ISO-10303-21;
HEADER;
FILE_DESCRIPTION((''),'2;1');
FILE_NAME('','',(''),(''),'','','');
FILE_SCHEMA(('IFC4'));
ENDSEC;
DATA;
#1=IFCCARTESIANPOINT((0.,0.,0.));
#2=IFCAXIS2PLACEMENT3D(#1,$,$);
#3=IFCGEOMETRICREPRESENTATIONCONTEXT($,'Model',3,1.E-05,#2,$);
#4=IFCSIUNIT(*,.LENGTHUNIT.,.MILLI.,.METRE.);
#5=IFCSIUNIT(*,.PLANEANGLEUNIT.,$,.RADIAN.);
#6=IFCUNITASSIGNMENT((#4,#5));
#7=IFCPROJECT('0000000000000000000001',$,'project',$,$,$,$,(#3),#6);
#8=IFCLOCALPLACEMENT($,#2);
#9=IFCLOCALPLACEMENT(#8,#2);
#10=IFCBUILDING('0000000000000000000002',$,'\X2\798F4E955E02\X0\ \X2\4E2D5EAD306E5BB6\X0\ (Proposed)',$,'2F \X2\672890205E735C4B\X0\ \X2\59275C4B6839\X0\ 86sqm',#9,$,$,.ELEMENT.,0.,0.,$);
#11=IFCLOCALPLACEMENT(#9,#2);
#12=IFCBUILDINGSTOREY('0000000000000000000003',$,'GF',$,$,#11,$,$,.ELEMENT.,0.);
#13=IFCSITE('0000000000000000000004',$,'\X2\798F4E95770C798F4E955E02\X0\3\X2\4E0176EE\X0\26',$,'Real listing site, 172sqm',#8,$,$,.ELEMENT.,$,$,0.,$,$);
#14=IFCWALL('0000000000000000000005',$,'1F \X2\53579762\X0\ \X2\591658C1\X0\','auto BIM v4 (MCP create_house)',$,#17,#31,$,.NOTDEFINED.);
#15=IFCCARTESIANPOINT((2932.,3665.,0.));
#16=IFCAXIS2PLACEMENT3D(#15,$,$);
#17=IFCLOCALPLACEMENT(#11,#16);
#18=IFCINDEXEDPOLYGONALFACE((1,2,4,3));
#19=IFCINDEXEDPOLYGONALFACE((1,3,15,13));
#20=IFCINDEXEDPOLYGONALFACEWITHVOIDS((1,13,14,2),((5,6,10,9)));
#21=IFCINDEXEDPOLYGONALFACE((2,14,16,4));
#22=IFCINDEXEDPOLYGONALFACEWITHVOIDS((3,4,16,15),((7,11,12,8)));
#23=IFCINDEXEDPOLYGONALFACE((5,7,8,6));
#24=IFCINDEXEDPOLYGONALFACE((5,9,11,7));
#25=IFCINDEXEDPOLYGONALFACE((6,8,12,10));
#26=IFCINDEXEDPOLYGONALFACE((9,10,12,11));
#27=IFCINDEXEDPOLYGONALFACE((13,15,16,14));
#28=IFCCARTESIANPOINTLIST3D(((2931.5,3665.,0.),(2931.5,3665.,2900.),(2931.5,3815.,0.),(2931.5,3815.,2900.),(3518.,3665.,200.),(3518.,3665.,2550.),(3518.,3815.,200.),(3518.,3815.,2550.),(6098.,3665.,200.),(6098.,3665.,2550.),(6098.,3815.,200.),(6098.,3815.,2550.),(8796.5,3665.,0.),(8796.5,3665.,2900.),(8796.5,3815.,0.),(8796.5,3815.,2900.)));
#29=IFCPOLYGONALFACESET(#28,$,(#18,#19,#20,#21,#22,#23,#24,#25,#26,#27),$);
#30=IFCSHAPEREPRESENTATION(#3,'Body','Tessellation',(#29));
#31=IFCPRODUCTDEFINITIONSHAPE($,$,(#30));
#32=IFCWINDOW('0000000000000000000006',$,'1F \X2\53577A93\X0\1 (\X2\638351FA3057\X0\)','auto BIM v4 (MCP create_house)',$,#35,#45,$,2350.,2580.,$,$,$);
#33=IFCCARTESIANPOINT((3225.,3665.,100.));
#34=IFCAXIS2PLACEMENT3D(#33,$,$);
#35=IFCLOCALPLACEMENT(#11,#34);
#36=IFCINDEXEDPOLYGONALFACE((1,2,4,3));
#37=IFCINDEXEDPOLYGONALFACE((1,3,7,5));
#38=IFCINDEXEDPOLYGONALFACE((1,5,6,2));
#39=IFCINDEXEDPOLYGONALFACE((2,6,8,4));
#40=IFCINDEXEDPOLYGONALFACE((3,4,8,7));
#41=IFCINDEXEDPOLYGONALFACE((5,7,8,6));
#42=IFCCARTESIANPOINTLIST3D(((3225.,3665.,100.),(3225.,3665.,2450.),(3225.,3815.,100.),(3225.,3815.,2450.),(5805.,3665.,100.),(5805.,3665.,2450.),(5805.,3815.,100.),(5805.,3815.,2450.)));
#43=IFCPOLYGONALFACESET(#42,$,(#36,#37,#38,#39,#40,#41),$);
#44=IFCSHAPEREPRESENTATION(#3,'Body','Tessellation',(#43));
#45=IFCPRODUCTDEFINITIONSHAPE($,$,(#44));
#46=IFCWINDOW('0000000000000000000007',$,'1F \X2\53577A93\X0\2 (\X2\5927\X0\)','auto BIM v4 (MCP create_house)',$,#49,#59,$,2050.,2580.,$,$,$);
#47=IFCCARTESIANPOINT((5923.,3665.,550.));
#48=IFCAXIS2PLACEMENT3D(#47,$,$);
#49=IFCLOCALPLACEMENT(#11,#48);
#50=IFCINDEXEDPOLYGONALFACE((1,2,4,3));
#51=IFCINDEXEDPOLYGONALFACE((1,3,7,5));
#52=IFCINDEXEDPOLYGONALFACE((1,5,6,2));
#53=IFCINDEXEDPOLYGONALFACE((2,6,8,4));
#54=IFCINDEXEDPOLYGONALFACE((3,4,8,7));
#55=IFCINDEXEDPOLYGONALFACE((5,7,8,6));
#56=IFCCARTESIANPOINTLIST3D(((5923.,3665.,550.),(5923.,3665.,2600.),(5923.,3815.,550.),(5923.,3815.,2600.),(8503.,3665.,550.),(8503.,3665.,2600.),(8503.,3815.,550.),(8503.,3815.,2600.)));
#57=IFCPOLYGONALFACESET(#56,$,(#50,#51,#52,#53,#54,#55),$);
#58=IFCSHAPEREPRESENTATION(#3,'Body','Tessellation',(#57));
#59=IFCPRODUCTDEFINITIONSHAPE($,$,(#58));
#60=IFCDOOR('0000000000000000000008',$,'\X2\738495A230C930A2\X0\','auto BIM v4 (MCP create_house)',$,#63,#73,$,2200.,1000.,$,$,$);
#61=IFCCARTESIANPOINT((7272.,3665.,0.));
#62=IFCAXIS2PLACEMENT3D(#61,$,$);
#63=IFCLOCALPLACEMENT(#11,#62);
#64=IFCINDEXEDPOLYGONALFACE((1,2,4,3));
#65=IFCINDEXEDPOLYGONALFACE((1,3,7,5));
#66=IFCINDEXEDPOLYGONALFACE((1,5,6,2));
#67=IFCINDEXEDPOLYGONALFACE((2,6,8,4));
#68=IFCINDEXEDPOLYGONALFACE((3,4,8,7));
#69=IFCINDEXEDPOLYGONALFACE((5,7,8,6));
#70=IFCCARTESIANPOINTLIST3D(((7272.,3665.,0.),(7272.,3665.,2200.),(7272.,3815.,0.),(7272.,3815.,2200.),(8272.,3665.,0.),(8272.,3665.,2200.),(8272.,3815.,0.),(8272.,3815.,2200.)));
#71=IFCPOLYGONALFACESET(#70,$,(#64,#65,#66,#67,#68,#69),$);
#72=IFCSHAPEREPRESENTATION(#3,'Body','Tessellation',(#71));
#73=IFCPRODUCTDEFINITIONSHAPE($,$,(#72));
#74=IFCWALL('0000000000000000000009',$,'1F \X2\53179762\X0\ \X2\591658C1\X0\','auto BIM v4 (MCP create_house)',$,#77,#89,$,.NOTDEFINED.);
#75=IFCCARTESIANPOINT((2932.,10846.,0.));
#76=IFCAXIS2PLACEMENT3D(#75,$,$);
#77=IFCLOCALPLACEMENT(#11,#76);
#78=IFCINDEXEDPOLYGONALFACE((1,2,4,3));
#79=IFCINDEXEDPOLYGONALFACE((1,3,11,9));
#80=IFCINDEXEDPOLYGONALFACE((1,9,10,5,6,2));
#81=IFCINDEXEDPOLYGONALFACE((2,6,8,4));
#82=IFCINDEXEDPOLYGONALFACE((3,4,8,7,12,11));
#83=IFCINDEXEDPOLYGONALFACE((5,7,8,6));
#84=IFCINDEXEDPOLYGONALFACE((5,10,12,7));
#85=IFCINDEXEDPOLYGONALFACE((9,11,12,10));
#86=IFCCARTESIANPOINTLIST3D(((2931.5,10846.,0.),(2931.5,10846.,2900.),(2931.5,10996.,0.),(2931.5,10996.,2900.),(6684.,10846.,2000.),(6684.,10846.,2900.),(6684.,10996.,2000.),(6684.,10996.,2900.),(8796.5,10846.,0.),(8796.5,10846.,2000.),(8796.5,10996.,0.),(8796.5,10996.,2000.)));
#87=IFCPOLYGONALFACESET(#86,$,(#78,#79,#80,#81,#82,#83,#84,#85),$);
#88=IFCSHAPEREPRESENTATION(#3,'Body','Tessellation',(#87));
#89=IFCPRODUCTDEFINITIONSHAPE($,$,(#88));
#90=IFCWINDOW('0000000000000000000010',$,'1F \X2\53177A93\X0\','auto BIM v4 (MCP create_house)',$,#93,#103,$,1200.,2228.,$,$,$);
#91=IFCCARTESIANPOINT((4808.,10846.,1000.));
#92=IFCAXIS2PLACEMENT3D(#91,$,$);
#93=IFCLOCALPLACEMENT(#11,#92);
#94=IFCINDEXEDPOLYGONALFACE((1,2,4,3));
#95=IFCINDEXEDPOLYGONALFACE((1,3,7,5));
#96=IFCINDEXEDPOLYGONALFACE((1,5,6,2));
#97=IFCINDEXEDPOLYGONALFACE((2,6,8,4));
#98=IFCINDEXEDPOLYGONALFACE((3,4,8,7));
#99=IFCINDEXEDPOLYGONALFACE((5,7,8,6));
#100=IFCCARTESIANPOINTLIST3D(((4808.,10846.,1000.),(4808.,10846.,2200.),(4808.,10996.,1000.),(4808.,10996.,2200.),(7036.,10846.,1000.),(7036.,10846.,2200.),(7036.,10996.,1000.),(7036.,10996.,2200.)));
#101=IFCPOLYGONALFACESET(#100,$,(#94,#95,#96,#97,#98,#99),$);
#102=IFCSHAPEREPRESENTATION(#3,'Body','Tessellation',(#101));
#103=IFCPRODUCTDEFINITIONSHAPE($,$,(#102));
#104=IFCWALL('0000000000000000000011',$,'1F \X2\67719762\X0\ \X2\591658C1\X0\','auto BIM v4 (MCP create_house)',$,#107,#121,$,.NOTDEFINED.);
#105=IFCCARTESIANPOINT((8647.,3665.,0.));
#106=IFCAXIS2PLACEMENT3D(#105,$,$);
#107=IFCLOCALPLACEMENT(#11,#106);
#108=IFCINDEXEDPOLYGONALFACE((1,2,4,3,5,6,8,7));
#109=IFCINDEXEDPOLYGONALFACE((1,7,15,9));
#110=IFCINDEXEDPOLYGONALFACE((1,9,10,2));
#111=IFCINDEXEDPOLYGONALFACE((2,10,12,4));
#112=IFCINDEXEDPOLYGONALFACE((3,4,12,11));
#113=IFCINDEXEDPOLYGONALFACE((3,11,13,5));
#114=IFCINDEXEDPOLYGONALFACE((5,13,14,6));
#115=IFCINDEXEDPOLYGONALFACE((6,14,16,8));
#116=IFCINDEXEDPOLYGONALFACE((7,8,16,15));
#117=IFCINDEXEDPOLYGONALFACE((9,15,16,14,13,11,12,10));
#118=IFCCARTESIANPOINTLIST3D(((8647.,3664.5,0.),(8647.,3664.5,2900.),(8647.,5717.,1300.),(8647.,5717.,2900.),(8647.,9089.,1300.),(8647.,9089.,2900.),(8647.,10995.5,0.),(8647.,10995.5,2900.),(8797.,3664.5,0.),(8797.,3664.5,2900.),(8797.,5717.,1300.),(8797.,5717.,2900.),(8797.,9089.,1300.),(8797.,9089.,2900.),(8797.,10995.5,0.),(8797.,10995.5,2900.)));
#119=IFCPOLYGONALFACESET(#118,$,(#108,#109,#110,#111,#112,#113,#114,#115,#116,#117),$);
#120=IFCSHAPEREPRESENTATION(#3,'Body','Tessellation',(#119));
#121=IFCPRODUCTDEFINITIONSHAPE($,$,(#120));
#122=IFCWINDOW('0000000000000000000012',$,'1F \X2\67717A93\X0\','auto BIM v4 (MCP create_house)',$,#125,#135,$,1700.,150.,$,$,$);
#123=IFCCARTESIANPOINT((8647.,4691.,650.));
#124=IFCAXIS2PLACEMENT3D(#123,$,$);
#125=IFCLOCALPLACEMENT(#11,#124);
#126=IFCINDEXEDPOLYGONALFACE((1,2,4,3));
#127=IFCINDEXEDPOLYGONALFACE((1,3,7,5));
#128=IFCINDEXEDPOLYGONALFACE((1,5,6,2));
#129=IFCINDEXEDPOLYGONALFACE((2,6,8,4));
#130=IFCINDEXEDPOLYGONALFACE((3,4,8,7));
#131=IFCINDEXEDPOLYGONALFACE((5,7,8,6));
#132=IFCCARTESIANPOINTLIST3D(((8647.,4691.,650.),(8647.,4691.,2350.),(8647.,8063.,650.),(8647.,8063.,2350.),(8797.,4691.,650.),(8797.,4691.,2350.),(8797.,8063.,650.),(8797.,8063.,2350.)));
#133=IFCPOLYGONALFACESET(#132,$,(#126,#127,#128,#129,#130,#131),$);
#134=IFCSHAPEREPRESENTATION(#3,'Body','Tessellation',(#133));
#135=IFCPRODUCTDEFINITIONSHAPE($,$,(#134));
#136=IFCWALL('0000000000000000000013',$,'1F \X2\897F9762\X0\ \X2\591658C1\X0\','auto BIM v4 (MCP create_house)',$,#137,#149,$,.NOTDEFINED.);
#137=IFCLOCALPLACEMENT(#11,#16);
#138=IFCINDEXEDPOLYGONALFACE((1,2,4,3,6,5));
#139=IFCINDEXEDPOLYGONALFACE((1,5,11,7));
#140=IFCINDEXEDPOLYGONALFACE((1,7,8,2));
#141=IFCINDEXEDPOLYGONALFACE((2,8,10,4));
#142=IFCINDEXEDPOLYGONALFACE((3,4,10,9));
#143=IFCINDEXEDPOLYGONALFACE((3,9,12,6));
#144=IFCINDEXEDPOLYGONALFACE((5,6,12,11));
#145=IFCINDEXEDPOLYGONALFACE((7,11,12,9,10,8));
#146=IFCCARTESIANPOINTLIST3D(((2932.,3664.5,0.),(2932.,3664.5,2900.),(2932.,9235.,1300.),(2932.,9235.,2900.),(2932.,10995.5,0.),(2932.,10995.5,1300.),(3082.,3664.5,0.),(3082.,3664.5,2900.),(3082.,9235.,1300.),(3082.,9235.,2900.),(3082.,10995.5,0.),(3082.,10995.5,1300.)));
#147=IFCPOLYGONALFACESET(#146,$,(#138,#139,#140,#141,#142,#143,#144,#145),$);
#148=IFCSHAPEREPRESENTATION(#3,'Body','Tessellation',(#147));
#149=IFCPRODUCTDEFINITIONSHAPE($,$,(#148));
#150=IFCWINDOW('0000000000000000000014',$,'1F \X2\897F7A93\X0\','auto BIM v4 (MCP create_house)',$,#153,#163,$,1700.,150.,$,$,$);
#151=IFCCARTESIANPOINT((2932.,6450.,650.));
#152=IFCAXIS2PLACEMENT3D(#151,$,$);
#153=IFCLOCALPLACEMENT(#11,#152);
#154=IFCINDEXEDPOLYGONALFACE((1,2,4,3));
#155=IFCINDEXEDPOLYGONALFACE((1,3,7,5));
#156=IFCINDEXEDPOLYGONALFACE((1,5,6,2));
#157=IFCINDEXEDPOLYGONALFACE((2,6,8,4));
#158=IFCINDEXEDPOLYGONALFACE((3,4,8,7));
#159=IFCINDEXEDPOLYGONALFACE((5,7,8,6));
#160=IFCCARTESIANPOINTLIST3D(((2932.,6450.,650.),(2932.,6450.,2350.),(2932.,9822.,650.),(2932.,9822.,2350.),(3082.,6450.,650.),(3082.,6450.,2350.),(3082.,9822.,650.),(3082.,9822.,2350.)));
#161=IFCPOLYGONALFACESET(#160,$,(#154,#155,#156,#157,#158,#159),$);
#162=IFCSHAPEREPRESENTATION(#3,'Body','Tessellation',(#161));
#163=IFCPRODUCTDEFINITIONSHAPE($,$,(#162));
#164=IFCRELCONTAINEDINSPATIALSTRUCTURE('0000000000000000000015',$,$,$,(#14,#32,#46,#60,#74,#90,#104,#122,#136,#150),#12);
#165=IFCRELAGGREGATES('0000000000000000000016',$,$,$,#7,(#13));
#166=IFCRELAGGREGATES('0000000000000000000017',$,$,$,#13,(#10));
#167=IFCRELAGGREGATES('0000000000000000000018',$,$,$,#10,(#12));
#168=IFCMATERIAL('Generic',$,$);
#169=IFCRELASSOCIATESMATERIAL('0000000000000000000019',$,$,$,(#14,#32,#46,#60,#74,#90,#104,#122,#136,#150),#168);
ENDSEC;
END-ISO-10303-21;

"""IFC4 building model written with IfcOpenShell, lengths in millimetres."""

from ifc_helpers import new_model, si_unit, frame, frame_2d, origin, place, context, project, spatial, rectangle, extrude, material, element, fill, save


model = new_model("IFC4")

# Units and contexts
model_context = context("Model", 3, precision=1e-05, world=origin())
ifc_project = project(units=[si_unit("LENGTHUNIT", "METRE", prefix="MILLI"), si_unit("PLANEANGLEUNIT", "RADIAN")], contexts=[model_context])

# Site, building, storey
site_placement = place(None, origin())
site = spatial("IfcSite", under=ifc_project, at=site_placement, Name="福井県福井市3丁目26", ObjectType="Real listing site, 172sqm", CompositionType="ELEMENT", RefElevation=0.0)
building_placement = place(site_placement, origin())
building = spatial("IfcBuilding", under=site, at=building_placement, Name="福井市 中庭の家 (Proposed)", ObjectType="2F 木造平屋 大屋根 86sqm", CompositionType="ELEMENT", ElevationOfRefHeight=0.0, ElevationOfTerrain=0.0)
storey_placement = place(building_placement, origin())
storey = spatial("IfcBuildingStorey", under=building, at=storey_placement, Name="GF", CompositionType="ELEMENT", Elevation=0.0)

# Shared definitions
ifc_material = material(Name="Generic")

# Wall, openings, windows, door
wall_1_placement = place(storey_placement, frame((2932.0, 3665.0, 0.0)))
wall_1 = element("IfcWall", 1, at=wall_1_placement, inside=storey, material=ifc_material, Name="1F 南面 外壁", Description="auto BIM v4 (MCP create_house)", PredefinedType="NOTDEFINED", context=model_context, shape_type="SweptSolid", body=[
    extrude(rectangle(XDim=5865.0, YDim=150.0, at=frame_2d((2932.0, 75.0))), frame((2932.0, 3665.0, 0.0)), (0.0, 0.0, 1.0), 2900.0),
])
opening_1_placement = place(storey_placement, frame((3225.0, 3665.0, 100.0)))
opening_1 = element("IfcOpeningElement", 2, at=opening_1_placement, cuts=wall_1, PredefinedType="NOTDEFINED", context=model_context, shape_type="SweptSolid", body=[
    extrude(rectangle(XDim=2580.0, YDim=150.0, at=frame_2d((1290.0, 75.0))), frame((3225.0, 3665.0, 100.0)), (0.0, 0.0, 1.0), 2350.0),
])
opening_2_placement = place(storey_placement, frame((5923.0, 3665.0, 550.0)))
opening_2 = element("IfcOpeningElement", 3, at=opening_2_placement, cuts=wall_1, PredefinedType="NOTDEFINED", context=model_context, shape_type="SweptSolid", body=[
    extrude(rectangle(XDim=2580.0, YDim=150.0, at=frame_2d((1290.0, 75.0))), frame((5923.0, 3665.0, 550.0)), (0.0, 0.0, 1.0), 2050.0),
])
opening_3_placement = place(storey_placement, frame((7272.0, 3665.0, 0.0)))
opening_3 = element("IfcOpeningElement", 4, at=opening_3_placement, cuts=wall_1, PredefinedType="NOTDEFINED", context=model_context, shape_type="SweptSolid", body=[
    extrude(rectangle(XDim=1000.0, YDim=150.0, at=frame_2d((500.0, 75.0))), frame((7272.0, 3665.0, 0.0)), (0.0, 0.0, 1.0), 2200.0),
])
window_1_placement = place(storey_placement, frame((3225.0, 3665.0, 100.0)))
window_1 = element("IfcWindow", 5, at=window_1_placement, inside=storey, material=ifc_material, Name="1F 南窓1 (掃出し)", Description="auto BIM v4 (MCP create_house)", OverallHeight=2350.0, OverallWidth=2580.0, context=model_context, shape_type="SweptSolid", body=[
    extrude(rectangle(XDim=2580.0, YDim=150.0, at=frame_2d((1290.0, 75.0))), frame((3225.0, 3665.0, 100.0)), (0.0, 0.0, 1.0), 2350.0),
])
fill(opening_1, window_1)
window_2_placement = place(storey_placement, frame((5923.0, 3665.0, 550.0)))
window_2 = element("IfcWindow", 6, at=window_2_placement, inside=storey, material=ifc_material, Name="1F 南窓2 (大)", Description="auto BIM v4 (MCP create_house)", OverallHeight=2050.0, OverallWidth=2580.0, context=model_context, shape_type="SweptSolid", body=[
    extrude(rectangle(XDim=2580.0, YDim=150.0, at=frame_2d((1290.0, 75.0))), frame((5923.0, 3665.0, 550.0)), (0.0, 0.0, 1.0), 2050.0),
])
fill(opening_2, window_2)
door_1_placement = place(storey_placement, frame((7272.0, 3665.0, 0.0)))
door_1 = element("IfcDoor", 7, at=door_1_placement, inside=storey, material=ifc_material, Name="玄関ドア", Description="auto BIM v4 (MCP create_house)", OverallHeight=2200.0, OverallWidth=1000.0, context=model_context, shape_type="SweptSolid", body=[
    extrude(rectangle(XDim=1000.0, YDim=150.0, at=frame_2d((500.0, 75.0))), frame((7272.0, 3665.0, 0.0)), (0.0, 0.0, 1.0), 2200.0),
])
fill(opening_3, door_1)

# Walls, openings, windows
wall_2_placement = place(storey_placement, frame((2932.0, 10846.0, 0.0)))
wall_2 = element("IfcWall", 8, at=wall_2_placement, inside=storey, material=ifc_material, Name="1F 北面 外壁", Description="auto BIM v4 (MCP create_house)", PredefinedType="NOTDEFINED", context=model_context, shape_type="SweptSolid", body=[
    extrude(rectangle(XDim=5865.0, YDim=150.0, at=frame_2d((2932.0, 75.0))), frame((2932.0, 10846.0, 0.0)), (0.0, 0.0, 1.0), 2900.0),
])
opening_4_placement = place(storey_placement, frame((4808.0, 10846.0, 1000.0)))
opening_4 = element("IfcOpeningElement", 9, at=opening_4_placement, cuts=wall_2, PredefinedType="NOTDEFINED", context=model_context, shape_type="SweptSolid", body=[
    extrude(rectangle(XDim=2228.0, YDim=150.0, at=frame_2d((1114.0, 75.0))), frame((4808.0, 10846.0, 1000.0)), (0.0, 0.0, 1.0), 1200.0),
])
window_3_placement = place(storey_placement, frame((4808.0, 10846.0, 1000.0)))
window_3 = element("IfcWindow", 10, at=window_3_placement, inside=storey, material=ifc_material, Name="1F 北窓", Description="auto BIM v4 (MCP create_house)", OverallHeight=1200.0, OverallWidth=2228.0, context=model_context, shape_type="SweptSolid", body=[
    extrude(rectangle(XDim=2228.0, YDim=150.0, at=frame_2d((1114.0, 75.0))), frame((4808.0, 10846.0, 1000.0)), (0.0, 0.0, 1.0), 1200.0),
])
fill(opening_4, window_3)
wall_3_placement = place(storey_placement, frame((8647.0, 3665.0, 0.0)))
wall_3 = element("IfcWall", 11, at=wall_3_placement, inside=storey, material=ifc_material, Name="1F 東面 外壁", Description="auto BIM v4 (MCP create_house)", PredefinedType="NOTDEFINED", context=model_context, shape_type="SweptSolid", body=[
    extrude(rectangle(XDim=150.0, YDim=7331.0, at=frame_2d((75.0, 3665.0))), frame((8647.0, 3665.0, 0.0)), (0.0, 0.0, 1.0), 2900.0),
])
opening_5_placement = place(storey_placement, frame((8647.0, 4691.0, 650.0)))
opening_5 = element("IfcOpeningElement", 12, at=opening_5_placement, cuts=wall_3, PredefinedType="NOTDEFINED", context=model_context, shape_type="SweptSolid", body=[
    extrude(rectangle(XDim=150.0, YDim=3372.0, at=frame_2d((75.0, 1686.0))), frame((8647.0, 4691.0, 650.0)), (0.0, 0.0, 1.0), 1700.0),
])
window_4_placement = place(storey_placement, frame((8647.0, 4691.0, 650.0)))
window_4 = element("IfcWindow", 13, at=window_4_placement, inside=storey, material=ifc_material, Name="1F 東窓", Description="auto BIM v4 (MCP create_house)", OverallHeight=1700.0, OverallWidth=150.0, context=model_context, shape_type="SweptSolid", body=[
    extrude(rectangle(XDim=150.0, YDim=3372.0, at=frame_2d((75.0, 1686.0))), frame((8647.0, 4691.0, 650.0)), (0.0, 0.0, 1.0), 1700.0),
])
fill(opening_5, window_4)
wall_4_placement = place(storey_placement, frame((2932.0, 3665.0, 0.0)))
wall_4 = element("IfcWall", 14, at=wall_4_placement, inside=storey, material=ifc_material, Name="1F 西面 外壁", Description="auto BIM v4 (MCP create_house)", PredefinedType="NOTDEFINED", context=model_context, shape_type="SweptSolid", body=[
    extrude(rectangle(XDim=150.0, YDim=7331.0, at=frame_2d((75.0, 3665.0))), frame((2932.0, 3665.0, 0.0)), (0.0, 0.0, 1.0), 2900.0),
])
opening_6_placement = place(storey_placement, frame((2932.0, 6450.0, 650.0)))
opening_6 = element("IfcOpeningElement", 15, at=opening_6_placement, cuts=wall_4, PredefinedType="NOTDEFINED", context=model_context, shape_type="SweptSolid", body=[
    extrude(rectangle(XDim=150.0, YDim=3372.0, at=frame_2d((75.0, 1686.0))), frame((2932.0, 6450.0, 650.0)), (0.0, 0.0, 1.0), 1700.0),
])
window_5_placement = place(storey_placement, frame((2932.0, 6450.0, 650.0)))
window_5 = element("IfcWindow", 16, at=window_5_placement, inside=storey, material=ifc_material, Name="1F 西窓", Description="auto BIM v4 (MCP create_house)", OverallHeight=1700.0, OverallWidth=150.0, context=model_context, shape_type="SweptSolid", body=[
    extrude(rectangle(XDim=150.0, YDim=3372.0, at=frame_2d((75.0, 1686.0))), frame((2932.0, 6450.0, 650.0)), (0.0, 0.0, 1.0), 1700.0),
])
fill(opening_6, window_5)

save(model, "model.ifc")
